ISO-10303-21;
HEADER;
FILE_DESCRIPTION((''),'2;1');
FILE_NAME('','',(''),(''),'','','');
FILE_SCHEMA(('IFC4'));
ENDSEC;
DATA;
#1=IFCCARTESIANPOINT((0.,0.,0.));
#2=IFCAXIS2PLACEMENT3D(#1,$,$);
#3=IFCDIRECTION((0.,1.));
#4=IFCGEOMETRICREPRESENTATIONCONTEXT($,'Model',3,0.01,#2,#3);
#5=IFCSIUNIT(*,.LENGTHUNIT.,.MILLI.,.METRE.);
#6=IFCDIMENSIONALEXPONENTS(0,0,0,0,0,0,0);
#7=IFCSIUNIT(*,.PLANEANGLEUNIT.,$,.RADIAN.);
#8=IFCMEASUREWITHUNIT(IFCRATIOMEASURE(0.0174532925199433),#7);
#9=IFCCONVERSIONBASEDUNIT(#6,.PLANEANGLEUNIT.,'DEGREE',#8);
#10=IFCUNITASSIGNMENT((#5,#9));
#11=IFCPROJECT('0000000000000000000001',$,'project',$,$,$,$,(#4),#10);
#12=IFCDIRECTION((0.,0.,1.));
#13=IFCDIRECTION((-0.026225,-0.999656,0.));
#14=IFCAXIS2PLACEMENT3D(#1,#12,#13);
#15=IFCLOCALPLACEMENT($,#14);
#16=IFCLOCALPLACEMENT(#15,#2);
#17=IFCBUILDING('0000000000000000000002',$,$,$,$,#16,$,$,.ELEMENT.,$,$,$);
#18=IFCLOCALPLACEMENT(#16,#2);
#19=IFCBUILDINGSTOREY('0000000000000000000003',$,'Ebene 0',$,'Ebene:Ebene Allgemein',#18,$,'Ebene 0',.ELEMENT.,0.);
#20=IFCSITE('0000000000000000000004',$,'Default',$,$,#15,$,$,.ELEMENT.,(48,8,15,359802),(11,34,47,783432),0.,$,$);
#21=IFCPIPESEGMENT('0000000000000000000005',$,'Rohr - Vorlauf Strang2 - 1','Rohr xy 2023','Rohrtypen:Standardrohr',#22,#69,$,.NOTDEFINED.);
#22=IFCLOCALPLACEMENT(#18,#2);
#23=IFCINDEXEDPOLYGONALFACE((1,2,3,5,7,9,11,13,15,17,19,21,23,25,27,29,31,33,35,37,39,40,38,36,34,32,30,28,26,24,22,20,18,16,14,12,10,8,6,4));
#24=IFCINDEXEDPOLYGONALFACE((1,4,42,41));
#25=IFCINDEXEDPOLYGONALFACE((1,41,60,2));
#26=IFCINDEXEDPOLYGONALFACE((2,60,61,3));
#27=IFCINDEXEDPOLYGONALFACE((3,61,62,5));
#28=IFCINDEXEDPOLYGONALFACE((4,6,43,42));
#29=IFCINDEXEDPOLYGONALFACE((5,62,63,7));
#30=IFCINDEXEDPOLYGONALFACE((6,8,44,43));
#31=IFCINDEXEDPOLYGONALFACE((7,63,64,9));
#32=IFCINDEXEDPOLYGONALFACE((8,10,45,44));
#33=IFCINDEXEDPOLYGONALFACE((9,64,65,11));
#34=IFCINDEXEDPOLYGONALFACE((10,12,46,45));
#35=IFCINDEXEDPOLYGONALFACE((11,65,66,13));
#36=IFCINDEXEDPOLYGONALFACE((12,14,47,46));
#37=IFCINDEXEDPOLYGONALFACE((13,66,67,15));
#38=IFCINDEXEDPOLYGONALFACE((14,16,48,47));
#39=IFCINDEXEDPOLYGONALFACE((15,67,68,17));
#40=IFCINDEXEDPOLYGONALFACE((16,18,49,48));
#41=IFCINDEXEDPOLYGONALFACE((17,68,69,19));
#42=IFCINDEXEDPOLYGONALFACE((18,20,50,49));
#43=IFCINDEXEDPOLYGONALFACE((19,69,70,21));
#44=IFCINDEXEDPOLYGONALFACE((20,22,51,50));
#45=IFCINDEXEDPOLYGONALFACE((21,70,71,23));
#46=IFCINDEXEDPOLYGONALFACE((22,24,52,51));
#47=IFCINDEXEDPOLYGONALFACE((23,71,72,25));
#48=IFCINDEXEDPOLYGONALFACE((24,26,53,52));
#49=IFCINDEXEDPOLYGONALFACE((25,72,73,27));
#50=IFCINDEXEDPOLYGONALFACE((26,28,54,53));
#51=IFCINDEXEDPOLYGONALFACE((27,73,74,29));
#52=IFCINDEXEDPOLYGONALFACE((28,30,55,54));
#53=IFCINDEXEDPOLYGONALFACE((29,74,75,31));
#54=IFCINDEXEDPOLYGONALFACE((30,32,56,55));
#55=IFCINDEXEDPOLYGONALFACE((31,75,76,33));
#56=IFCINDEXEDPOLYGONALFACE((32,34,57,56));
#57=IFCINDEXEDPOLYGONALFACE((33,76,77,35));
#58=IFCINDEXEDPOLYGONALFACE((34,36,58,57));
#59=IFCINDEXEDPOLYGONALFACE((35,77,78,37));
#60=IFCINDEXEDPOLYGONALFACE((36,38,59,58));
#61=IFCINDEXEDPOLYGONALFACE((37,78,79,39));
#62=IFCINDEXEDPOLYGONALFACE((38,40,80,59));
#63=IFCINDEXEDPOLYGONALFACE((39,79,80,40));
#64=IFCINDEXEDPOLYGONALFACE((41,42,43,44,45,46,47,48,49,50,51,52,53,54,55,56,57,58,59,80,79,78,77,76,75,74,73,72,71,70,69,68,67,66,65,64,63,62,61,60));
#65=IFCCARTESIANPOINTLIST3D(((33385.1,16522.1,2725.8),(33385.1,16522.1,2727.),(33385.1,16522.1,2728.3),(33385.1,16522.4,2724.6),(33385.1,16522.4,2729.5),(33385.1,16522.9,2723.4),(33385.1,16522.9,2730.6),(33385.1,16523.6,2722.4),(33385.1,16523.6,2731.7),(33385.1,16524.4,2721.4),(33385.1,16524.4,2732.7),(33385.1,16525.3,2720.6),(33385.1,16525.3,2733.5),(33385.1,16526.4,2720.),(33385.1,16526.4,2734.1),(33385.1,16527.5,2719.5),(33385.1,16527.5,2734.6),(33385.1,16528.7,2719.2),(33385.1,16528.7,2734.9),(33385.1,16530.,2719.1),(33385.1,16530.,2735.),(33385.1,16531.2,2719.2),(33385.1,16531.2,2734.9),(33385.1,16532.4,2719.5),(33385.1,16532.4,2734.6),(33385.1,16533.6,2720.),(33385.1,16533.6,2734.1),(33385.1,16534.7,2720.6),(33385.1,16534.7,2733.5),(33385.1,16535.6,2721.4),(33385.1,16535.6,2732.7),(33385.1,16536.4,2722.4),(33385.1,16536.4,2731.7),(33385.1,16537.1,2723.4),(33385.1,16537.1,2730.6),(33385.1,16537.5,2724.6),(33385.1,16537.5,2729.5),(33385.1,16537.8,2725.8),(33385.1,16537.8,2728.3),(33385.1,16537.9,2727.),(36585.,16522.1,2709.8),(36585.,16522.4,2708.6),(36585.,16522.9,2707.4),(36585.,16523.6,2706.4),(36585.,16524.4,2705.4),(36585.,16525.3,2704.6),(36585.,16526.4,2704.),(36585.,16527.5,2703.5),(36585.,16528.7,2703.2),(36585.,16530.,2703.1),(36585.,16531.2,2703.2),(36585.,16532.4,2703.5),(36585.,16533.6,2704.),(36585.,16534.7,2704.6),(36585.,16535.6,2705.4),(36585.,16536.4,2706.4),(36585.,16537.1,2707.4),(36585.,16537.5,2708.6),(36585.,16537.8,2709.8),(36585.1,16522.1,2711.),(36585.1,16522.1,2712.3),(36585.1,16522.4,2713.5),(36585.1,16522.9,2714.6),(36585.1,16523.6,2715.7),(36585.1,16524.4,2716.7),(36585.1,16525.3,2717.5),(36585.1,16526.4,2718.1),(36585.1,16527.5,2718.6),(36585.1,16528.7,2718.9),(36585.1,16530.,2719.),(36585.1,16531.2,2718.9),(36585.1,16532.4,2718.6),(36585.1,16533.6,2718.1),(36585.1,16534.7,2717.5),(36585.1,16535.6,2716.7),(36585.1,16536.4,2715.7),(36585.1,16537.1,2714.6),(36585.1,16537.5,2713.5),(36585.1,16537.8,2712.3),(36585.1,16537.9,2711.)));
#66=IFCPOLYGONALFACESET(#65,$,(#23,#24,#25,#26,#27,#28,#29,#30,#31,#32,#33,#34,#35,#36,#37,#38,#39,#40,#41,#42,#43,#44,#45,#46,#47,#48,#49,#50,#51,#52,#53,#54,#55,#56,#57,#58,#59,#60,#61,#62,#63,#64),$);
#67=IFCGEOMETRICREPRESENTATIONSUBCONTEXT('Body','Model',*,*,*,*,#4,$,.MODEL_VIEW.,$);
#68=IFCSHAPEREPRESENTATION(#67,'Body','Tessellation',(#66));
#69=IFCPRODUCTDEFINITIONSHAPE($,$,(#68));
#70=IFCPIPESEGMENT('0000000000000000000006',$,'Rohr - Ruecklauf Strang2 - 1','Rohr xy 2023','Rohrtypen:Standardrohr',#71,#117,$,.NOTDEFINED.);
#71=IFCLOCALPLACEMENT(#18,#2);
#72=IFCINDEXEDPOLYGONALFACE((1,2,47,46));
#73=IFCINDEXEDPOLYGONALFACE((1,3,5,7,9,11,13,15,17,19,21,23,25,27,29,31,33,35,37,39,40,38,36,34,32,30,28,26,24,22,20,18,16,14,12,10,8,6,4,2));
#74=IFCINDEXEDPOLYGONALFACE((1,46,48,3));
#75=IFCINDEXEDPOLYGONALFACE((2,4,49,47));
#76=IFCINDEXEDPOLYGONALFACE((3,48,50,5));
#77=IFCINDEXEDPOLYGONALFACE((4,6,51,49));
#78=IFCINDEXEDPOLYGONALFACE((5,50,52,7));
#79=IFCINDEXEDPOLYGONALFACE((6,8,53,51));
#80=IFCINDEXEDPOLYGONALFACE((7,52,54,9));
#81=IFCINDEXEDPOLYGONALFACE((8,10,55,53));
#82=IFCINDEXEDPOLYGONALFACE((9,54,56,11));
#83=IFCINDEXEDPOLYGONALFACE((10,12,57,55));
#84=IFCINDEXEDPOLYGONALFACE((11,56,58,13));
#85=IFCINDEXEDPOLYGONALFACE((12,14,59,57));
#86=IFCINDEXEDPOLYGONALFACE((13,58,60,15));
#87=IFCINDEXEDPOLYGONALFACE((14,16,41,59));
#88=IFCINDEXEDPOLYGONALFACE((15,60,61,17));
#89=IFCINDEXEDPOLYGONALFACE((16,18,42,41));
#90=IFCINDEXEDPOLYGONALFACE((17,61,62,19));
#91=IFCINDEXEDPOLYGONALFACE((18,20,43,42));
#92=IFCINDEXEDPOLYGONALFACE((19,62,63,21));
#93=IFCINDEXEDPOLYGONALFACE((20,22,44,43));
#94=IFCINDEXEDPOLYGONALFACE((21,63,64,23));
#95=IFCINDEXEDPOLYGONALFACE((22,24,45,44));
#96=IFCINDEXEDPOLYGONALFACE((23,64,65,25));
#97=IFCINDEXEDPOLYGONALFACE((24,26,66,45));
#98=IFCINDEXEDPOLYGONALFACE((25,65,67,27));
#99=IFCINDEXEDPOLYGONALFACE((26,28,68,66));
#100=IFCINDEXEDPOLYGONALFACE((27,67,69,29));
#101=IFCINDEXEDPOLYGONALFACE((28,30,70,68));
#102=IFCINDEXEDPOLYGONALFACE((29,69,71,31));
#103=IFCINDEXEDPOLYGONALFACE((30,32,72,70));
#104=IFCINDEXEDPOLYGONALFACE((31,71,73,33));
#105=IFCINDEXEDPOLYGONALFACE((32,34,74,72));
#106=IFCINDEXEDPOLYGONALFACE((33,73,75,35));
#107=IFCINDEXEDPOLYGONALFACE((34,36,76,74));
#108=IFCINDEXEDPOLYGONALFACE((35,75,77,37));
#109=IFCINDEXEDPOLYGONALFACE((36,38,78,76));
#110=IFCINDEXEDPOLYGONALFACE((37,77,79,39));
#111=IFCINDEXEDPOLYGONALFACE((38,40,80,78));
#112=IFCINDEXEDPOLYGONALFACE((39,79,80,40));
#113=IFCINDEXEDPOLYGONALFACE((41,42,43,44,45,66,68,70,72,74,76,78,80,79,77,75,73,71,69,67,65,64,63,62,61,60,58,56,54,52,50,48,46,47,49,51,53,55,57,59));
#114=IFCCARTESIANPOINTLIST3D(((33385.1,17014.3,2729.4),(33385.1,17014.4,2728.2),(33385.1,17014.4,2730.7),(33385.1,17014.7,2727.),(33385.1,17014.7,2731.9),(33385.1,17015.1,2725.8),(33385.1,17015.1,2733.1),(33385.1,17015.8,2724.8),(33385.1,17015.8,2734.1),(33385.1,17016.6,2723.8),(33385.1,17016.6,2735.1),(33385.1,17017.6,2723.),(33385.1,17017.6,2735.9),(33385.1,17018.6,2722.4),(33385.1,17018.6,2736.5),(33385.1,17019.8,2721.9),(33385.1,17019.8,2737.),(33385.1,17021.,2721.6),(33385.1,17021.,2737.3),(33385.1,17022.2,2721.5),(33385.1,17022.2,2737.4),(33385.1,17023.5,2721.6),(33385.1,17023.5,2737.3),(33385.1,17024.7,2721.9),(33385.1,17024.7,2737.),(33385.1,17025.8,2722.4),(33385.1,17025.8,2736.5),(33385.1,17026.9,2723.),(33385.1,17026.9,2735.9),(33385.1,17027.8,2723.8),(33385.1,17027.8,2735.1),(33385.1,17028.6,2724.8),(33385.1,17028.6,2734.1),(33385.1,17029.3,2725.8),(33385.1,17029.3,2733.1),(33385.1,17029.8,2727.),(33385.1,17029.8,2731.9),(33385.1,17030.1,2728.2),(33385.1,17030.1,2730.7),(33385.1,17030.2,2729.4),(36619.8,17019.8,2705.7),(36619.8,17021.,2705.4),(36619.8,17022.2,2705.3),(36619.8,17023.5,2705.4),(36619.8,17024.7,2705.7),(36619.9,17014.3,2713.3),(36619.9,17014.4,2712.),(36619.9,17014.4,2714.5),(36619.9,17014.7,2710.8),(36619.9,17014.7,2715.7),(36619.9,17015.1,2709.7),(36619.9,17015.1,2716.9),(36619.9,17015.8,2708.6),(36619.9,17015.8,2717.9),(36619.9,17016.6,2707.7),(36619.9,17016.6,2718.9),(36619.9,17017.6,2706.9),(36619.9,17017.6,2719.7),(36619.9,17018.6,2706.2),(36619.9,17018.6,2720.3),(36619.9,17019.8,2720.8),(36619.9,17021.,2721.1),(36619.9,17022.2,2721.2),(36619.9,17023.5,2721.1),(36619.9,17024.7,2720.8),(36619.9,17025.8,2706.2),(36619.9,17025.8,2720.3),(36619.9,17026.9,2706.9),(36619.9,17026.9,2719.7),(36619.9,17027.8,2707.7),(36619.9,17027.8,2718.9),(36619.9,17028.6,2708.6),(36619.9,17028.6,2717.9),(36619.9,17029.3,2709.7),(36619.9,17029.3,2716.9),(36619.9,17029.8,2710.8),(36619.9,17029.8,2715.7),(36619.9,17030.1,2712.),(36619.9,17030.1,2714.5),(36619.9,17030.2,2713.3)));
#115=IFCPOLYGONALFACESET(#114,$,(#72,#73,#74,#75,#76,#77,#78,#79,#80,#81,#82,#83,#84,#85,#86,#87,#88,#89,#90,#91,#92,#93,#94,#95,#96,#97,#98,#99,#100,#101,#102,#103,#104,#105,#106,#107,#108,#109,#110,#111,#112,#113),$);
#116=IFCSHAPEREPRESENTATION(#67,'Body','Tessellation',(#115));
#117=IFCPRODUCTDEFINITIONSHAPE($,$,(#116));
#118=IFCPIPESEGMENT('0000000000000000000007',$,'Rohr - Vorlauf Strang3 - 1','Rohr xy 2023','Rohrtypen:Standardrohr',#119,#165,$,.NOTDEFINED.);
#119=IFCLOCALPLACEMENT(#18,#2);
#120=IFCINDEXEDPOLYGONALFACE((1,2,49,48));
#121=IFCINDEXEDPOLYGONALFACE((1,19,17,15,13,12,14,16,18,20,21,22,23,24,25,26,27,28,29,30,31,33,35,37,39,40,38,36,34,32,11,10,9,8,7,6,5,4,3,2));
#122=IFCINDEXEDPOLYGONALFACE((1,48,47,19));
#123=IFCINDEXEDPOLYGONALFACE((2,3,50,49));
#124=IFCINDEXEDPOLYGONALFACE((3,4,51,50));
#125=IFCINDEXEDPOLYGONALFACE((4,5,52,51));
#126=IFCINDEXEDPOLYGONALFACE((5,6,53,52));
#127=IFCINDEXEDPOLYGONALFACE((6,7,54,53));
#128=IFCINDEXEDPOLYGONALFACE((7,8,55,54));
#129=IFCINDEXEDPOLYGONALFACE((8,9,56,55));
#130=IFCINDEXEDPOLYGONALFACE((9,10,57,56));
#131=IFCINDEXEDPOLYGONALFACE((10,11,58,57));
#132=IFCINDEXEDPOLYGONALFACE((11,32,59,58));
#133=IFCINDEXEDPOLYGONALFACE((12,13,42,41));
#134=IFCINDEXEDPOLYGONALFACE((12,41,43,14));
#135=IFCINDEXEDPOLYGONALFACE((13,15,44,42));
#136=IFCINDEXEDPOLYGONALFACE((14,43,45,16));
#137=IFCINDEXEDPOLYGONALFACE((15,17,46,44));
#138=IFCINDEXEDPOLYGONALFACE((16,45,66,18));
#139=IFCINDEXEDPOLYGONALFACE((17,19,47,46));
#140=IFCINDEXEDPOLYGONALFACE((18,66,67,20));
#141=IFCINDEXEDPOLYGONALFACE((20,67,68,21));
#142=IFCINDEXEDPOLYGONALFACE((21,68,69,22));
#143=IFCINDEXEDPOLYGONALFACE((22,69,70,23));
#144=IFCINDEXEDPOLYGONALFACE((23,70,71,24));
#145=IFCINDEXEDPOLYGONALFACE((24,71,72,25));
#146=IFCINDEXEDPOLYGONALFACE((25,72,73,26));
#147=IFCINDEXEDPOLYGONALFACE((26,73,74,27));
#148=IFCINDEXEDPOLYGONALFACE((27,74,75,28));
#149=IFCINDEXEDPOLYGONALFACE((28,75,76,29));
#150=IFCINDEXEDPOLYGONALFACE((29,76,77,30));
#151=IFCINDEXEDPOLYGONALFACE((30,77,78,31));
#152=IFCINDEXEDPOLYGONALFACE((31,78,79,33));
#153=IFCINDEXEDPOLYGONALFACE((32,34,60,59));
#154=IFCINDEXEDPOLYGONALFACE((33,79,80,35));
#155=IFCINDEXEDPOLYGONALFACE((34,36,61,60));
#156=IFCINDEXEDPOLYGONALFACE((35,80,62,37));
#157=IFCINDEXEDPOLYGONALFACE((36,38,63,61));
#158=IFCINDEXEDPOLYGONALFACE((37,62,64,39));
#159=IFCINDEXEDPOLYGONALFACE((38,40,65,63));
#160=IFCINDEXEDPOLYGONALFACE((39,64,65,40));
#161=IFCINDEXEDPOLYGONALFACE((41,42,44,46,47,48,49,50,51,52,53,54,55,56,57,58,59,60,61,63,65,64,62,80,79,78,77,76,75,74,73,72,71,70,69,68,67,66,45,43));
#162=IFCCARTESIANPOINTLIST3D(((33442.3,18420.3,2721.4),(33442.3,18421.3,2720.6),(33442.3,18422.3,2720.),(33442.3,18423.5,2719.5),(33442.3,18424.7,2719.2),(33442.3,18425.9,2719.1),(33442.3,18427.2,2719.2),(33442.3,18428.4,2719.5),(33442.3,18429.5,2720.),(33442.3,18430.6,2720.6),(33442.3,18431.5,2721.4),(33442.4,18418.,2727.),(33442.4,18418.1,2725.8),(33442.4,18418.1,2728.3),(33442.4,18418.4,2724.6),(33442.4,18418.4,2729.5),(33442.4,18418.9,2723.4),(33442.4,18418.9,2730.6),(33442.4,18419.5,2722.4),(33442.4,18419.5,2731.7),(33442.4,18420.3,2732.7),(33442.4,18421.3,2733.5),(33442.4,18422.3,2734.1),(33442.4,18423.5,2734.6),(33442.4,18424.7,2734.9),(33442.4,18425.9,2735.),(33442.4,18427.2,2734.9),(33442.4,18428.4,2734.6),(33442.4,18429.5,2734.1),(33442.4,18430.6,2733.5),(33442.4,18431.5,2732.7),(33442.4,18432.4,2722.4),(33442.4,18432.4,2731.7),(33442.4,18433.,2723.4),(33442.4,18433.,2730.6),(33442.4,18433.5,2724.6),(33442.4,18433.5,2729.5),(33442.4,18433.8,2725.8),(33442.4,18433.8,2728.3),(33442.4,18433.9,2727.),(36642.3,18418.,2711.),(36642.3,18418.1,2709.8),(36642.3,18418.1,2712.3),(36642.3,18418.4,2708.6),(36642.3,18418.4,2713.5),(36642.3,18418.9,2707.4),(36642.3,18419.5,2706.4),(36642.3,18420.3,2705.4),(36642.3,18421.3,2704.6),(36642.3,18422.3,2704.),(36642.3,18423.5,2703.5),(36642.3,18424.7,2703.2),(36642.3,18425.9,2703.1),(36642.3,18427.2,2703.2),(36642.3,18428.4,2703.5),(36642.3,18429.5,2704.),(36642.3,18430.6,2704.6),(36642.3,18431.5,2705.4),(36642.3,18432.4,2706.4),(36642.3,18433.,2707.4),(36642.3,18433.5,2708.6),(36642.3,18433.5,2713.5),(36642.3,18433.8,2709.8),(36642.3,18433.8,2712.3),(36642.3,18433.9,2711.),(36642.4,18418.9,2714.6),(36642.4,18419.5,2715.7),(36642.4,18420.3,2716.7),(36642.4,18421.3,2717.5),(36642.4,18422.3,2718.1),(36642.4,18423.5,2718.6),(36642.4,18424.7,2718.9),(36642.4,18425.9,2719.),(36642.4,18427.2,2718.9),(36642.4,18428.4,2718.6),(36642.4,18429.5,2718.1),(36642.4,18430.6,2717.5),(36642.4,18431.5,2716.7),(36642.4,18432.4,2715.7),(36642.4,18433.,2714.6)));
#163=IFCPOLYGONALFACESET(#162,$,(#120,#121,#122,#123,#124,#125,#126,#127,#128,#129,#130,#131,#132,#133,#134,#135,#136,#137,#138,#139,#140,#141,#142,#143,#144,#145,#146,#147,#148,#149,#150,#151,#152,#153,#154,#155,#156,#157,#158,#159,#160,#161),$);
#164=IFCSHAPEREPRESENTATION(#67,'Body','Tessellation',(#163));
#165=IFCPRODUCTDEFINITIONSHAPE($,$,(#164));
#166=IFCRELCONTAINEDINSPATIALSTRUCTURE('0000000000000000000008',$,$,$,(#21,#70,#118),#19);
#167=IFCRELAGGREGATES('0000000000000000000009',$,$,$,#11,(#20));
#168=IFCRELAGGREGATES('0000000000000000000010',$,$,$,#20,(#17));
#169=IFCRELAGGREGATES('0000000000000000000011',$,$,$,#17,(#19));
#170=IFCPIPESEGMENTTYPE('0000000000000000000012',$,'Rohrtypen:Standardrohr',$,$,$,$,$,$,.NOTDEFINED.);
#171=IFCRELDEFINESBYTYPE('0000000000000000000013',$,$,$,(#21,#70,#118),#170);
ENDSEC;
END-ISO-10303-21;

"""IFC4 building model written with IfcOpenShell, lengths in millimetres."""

from ifc_helpers import new_model, entity, si_unit, converted_unit, direction, frame, origin, place, context, subcontext, project, spatial, indexed_curve, outline, extrude, type_object, element, save


model = new_model("IFC4")

# Units and contexts
model_context = context("Model", 3, precision=0.01, world=origin(), true_north=direction((0.0, 1.0)))
body_context = subcontext(model_context, "Body", "Model", "MODEL_VIEW")
ifc_project = project(units=[si_unit("LENGTHUNIT", "METRE", prefix="MILLI"), converted_unit("PLANEANGLEUNIT", "DEGREE", entity("IfcRatioMeasure", 0.0174532925199433), si_unit("PLANEANGLEUNIT", "RADIAN"), dimensions=[0, 0, 0, 0, 0, 0, 0])], contexts=[model_context])

# Site, building, storey
site_placement = place(None, frame((0.0, 0.0, 0.0), z_axis=(0.0, 0.0, 1.0), x_axis=(-0.026225, -0.999656, 0.0)))
site = spatial("IfcSite", under=ifc_project, at=site_placement, Name="Default", CompositionType="ELEMENT", RefLatitude=(48, 8, 15, 359802), RefLongitude=(11, 34, 47, 783432), RefElevation=0.0)
building_placement = place(site_placement, origin())
building = spatial("IfcBuilding", under=site, at=building_placement, CompositionType="ELEMENT")
storey_placement = place(building_placement, origin())
storey = spatial("IfcBuildingStorey", under=building, at=storey_placement, Name="Ebene 0", ObjectType="Ebene:Ebene Allgemein", LongName="Ebene 0", CompositionType="ELEMENT", Elevation=0.0)

# Pipe segments
pipe_segment_type = type_object("IfcPipeSegmentType", Name="Rohrtypen:Standardrohr", PredefinedType="NOTDEFINED")
pipe_segment_1_placement = place(storey_placement, origin())
element("IfcPipeSegment", 1, at=pipe_segment_1_placement, inside=storey, type_object=pipe_segment_type, Name="Rohr - Vorlauf Strang2 - 1", Description="Rohr xy 2023", ObjectType="Rohrtypen:Standardrohr", PredefinedType="NOTDEFINED", context=body_context, shape_type="SweptSolid", body=[
    extrude(outline(indexed_curve([(7.9, 0.0), (7.8, 1.2), (7.6, 2.5), (7.1, 3.6), (6.4, 4.7), (5.6, 5.6), (4.7, 6.4), (3.6, 7.1), (2.5, 7.6), (1.2, 7.8), (0.0, 7.9), (-1.2, 7.8), (-2.5, 7.6), (-3.6, 7.1), (-4.7, 6.4), (-5.6, 5.6), (-6.4, 4.7), (-7.1, 3.6), (-7.6, 2.5), (-7.8, 1.2), (-7.9, 0.0), (-7.8, -1.2), (-7.6, -2.5), (-7.1, -3.6), (-6.4, -4.7), (-5.6, -5.6), (-4.7, -6.4), (-3.6, -7.1), (-2.5, -7.6), (-1.2, -7.8), (0.0, -7.9), (1.2, -7.8), (2.5, -7.6), (3.6, -7.1), (4.7, -6.4), (5.6, -5.6), (6.4, -4.7), (7.1, -3.6), (7.6, -2.5), (7.8, -1.2), (7.9, 0.0)], self_intersect=False)), frame((36585.1, 16530.0, 2711.0), z_axis=(-0.999988, 0.0, 0.005), x_axis=(0.0, 1.0, 0.0)), (0.0, 0.0, 1.0), 3200.0),
])
pipe_segment_2_placement = place(storey_placement, origin())
element("IfcPipeSegment", 2, at=pipe_segment_2_placement, inside=storey, type_object=pipe_segment_type, Name="Rohr - Ruecklauf Strang2 - 1", Description="Rohr xy 2023", ObjectType="Rohrtypen:Standardrohr", PredefinedType="NOTDEFINED", context=body_context, shape_type="SweptSolid", body=[
    extrude(outline(indexed_curve([(7.9, 0.0), (7.8, 1.2), (7.6, 2.5), (7.1, 3.6), (6.4, 4.7), (5.6, 5.6), (4.7, 6.4), (3.6, 7.1), (2.5, 7.6), (1.2, 7.8), (0.0, 7.9), (-1.2, 7.8), (-2.5, 7.6), (-3.6, 7.1), (-4.7, 6.4), (-5.6, 5.6), (-6.4, 4.7), (-7.1, 3.6), (-7.6, 2.5), (-7.8, 1.2), (-7.9, 0.0), (-7.8, -1.2), (-7.6, -2.5), (-7.1, -3.6), (-6.4, -4.7), (-5.6, -5.6), (-4.7, -6.4), (-3.6, -7.1), (-2.5, -7.6), (-1.2, -7.8), (0.0, -7.9), (1.2, -7.8), (2.5, -7.6), (3.6, -7.1), (4.7, -6.4), (5.6, -5.6), (6.4, -4.7), (7.1, -3.6), (7.6, -2.5), (7.8, -1.2), (7.9, 0.0)], self_intersect=False)), frame((36619.9, 17022.2, 2713.3), z_axis=(-0.999988, 0.0, 0.005), x_axis=(0.0, 1.0, 0.0)), (0.0, 0.0, 1.0), 3234.8),
])
pipe_segment_3_placement = place(storey_placement, origin())
element("IfcPipeSegment", 3, at=pipe_segment_3_placement, inside=storey, type_object=pipe_segment_type, Name="Rohr - Vorlauf Strang3 - 1", Description="Rohr xy 2023", ObjectType="Rohrtypen:Standardrohr", PredefinedType="NOTDEFINED", context=body_context, shape_type="SweptSolid", body=[
    extrude(outline(indexed_curve([(7.9, 0.0), (7.8, 1.2), (7.6, 2.5), (7.1, 3.6), (6.4, 4.7), (5.6, 5.6), (4.7, 6.4), (3.6, 7.1), (2.5, 7.6), (1.2, 7.8), (0.0, 7.9), (-1.2, 7.8), (-2.5, 7.6), (-3.6, 7.1), (-4.7, 6.4), (-5.6, 5.6), (-6.4, 4.7), (-7.1, 3.6), (-7.6, 2.5), (-7.8, 1.2), (-7.9, 0.0), (-7.8, -1.2), (-7.6, -2.5), (-7.1, -3.6), (-6.4, -4.7), (-5.6, -5.6), (-4.7, -6.4), (-3.6, -7.1), (-2.5, -7.6), (-1.2, -7.8), (0.0, -7.9), (1.2, -7.8), (2.5, -7.6), (3.6, -7.1), (4.7, -6.4), (5.6, -5.6), (6.4, -4.7), (7.1, -3.6), (7.6, -2.5), (7.8, -1.2), (7.9, 0.0)], self_intersect=False)), frame((36642.3, 18425.9, 2711.0), z_axis=(-0.999988, 0.0, 0.005), x_axis=(0.0, 1.0, 0.0)), (0.0, 0.0, 1.0), 3200.0),
])

save(model, "model.ifc")
